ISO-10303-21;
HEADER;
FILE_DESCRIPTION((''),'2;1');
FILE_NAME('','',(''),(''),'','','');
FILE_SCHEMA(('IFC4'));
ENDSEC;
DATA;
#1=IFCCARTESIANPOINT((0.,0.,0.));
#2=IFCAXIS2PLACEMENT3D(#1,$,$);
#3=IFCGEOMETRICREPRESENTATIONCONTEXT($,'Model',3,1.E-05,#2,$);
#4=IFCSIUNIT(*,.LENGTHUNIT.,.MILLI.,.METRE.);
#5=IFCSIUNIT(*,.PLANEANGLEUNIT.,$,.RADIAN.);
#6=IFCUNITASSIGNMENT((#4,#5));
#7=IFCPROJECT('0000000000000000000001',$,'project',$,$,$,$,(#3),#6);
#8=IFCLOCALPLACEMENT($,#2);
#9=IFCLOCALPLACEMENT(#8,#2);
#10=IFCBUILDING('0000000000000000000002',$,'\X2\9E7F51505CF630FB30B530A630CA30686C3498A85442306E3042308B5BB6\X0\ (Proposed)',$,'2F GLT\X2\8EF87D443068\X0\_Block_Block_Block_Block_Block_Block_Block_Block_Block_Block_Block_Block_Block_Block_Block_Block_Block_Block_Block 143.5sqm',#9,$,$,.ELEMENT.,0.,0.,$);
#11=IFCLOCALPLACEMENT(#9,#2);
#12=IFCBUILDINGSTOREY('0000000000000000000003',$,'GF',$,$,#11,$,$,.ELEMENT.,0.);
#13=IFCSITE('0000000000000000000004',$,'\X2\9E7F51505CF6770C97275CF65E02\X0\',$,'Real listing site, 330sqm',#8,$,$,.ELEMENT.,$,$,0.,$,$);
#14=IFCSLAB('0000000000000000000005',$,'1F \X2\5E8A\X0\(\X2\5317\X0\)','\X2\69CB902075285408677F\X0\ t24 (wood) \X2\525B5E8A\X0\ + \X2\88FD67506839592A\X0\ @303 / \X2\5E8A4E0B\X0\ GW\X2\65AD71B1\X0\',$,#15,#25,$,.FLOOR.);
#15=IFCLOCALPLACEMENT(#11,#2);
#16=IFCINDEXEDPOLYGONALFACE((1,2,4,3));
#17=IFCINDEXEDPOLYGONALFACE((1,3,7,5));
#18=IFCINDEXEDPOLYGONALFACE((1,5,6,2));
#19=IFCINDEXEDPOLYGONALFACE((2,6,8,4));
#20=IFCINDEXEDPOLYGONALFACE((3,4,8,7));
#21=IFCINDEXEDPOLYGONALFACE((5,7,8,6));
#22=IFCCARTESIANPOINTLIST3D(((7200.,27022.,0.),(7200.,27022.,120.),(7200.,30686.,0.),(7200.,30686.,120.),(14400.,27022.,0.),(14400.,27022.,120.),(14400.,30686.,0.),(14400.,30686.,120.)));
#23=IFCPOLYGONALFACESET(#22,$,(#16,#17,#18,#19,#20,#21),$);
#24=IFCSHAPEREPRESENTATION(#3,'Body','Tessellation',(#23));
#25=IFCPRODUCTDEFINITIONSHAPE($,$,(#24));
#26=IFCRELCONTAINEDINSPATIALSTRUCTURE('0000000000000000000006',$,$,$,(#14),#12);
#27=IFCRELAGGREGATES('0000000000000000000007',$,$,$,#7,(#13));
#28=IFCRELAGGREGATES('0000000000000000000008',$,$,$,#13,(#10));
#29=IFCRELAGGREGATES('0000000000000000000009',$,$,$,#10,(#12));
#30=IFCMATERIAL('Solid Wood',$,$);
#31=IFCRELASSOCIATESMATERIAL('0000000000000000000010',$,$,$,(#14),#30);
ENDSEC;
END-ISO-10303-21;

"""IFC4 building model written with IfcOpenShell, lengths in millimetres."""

from ifc_helpers import new_model, si_unit, frame, frame_2d, origin, place, context, project, spatial, rectangle, extrude, material, element, save


model = new_model("IFC4")

# Units and contexts
model_context = context("Model", 3, precision=1e-05, world=origin())
ifc_project = project(units=[si_unit("LENGTHUNIT", "METRE", prefix="MILLI"), si_unit("PLANEANGLEUNIT", "RADIAN")], contexts=[model_context])

# Site, building, storey
site_placement = place(None, origin())
site = spatial("IfcSite", under=ifc_project, at=site_placement, Name="鹿児島県霧島市", ObjectType="Real listing site, 330sqm", CompositionType="ELEMENT", RefElevation=0.0)
building_placement = place(site_placement, origin())
building = spatial("IfcBuilding", under=site, at=building_placement, Name="鹿児島・サウナと水風呂のある家 (Proposed)", ObjectType="2F GLT軸組と_Block_Block_Block_Block_Block_Block_Block_Block_Block_Block_Block_Block_Block_Block_Block_Block_Block_Block_Block 143.5sqm", CompositionType="ELEMENT", ElevationOfRefHeight=0.0, ElevationOfTerrain=0.0)
storey_placement = place(building_placement, origin())
storey = spatial("IfcBuildingStorey", under=building, at=storey_placement, Name="GF", CompositionType="ELEMENT", Elevation=0.0)

# Shared definitions
ifc_material_1 = material(Name="Solid Wood")

# Slab
slab_1_placement = place(storey_placement, frame((3600.0, 13511.0, 0.0)))
element("IfcSlab", 1, at=slab_1_placement, inside=storey, material=ifc_material_1, Name="1F 床(北)", Description="構造用合板 t24 (wood) 剛床 + 製材根太 @303 / 床下 GW断熱", PredefinedType="FLOOR", context=model_context, shape_type="SweptSolid", body=[
    extrude(rectangle(XDim=7200.0, YDim=3664.0, at=frame_2d((3600.0, 1832.0))), frame((3600.0, 13511.0, 0.0)), (0.0, 0.0, 1.0), 120.0),
])

save(model, "model.ifc")
